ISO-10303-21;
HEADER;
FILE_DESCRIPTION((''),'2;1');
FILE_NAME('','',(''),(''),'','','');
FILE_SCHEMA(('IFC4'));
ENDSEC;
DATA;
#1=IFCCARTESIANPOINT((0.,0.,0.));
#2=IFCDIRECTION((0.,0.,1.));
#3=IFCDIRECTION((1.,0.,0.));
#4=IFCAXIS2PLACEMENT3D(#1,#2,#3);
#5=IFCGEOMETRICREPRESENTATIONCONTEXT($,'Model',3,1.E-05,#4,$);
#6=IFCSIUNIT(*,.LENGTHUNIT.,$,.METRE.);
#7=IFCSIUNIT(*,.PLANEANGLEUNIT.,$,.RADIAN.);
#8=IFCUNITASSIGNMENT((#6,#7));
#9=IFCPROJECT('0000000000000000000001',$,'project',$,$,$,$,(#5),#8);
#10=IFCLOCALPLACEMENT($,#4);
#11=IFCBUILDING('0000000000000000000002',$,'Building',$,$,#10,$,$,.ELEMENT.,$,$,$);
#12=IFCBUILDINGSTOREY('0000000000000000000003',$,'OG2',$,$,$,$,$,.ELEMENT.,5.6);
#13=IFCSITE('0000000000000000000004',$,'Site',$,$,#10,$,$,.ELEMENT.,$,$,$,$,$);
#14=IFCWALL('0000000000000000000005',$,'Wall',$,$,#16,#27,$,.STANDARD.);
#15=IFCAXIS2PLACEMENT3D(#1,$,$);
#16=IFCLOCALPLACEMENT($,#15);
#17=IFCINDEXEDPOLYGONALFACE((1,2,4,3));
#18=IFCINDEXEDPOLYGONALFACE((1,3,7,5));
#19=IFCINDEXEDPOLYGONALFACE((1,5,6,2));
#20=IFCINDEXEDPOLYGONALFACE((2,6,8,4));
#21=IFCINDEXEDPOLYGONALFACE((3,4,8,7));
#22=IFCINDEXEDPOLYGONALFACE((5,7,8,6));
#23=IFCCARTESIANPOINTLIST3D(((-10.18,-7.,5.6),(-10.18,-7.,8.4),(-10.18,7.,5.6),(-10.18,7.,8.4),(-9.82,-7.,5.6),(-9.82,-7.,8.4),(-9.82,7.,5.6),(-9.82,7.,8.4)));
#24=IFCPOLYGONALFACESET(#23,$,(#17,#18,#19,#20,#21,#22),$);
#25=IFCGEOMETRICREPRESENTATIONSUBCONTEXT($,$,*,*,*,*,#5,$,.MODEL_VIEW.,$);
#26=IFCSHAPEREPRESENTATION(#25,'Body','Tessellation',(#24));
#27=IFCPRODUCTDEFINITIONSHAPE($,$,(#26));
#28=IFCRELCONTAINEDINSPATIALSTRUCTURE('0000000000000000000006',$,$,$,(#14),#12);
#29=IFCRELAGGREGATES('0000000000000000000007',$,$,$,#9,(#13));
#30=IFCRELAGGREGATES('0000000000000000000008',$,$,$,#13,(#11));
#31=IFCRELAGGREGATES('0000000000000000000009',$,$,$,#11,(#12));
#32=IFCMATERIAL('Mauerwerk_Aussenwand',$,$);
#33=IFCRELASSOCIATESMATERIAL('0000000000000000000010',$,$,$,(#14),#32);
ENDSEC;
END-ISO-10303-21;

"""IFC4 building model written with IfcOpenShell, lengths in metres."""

from ifc_helpers import new_model, si_unit, frame, frame_2d, origin, origin_with_axes, place, context, subcontext, project, spatial, rectangle, extrude, material, element, save


model = new_model("IFC4")

# Units and contexts
model_context = context("Model", 3, precision=1e-05, world=origin_with_axes())
sub_context = subcontext(model_context, None, None, "MODEL_VIEW")
ifc_project = project(units=[si_unit("LENGTHUNIT", "METRE"), si_unit("PLANEANGLEUNIT", "RADIAN")], contexts=[model_context])

# Site, building, storey
placement_1 = place(None, origin_with_axes())
site = spatial("IfcSite", under=ifc_project, at=placement_1, Name="Site", CompositionType="ELEMENT")
building = spatial("IfcBuilding", under=site, at=placement_1, Name="Building", CompositionType="ELEMENT")
storey = spatial("IfcBuildingStorey", under=building, Name="OG2", CompositionType="ELEMENT", Elevation=5.6)

# Wall
ifc_material = material(Name="Mauerwerk_Aussenwand")
placement_2 = place(None, origin_with_axes())
placement_3 = place(placement_2, frame((0.0, 0.0, 5.6)))
wall_placement = place(placement_3, frame((-10.0, 7.0, 0.0), x_axis=(0.0, -1.0, 0.0)))
element("IfcWall", 1, at=wall_placement, inside=storey, material=ifc_material, Name="Wall", PredefinedType="STANDARD", context=sub_context, shape_type="SweptSolid", body=[
    extrude(rectangle(XDim=14.0, YDim=0.36, at=frame_2d((7.0, 0.0))), origin(), (0.0, 0.0, 1.0), 2.8),
])

save(model, "model.ifc")
